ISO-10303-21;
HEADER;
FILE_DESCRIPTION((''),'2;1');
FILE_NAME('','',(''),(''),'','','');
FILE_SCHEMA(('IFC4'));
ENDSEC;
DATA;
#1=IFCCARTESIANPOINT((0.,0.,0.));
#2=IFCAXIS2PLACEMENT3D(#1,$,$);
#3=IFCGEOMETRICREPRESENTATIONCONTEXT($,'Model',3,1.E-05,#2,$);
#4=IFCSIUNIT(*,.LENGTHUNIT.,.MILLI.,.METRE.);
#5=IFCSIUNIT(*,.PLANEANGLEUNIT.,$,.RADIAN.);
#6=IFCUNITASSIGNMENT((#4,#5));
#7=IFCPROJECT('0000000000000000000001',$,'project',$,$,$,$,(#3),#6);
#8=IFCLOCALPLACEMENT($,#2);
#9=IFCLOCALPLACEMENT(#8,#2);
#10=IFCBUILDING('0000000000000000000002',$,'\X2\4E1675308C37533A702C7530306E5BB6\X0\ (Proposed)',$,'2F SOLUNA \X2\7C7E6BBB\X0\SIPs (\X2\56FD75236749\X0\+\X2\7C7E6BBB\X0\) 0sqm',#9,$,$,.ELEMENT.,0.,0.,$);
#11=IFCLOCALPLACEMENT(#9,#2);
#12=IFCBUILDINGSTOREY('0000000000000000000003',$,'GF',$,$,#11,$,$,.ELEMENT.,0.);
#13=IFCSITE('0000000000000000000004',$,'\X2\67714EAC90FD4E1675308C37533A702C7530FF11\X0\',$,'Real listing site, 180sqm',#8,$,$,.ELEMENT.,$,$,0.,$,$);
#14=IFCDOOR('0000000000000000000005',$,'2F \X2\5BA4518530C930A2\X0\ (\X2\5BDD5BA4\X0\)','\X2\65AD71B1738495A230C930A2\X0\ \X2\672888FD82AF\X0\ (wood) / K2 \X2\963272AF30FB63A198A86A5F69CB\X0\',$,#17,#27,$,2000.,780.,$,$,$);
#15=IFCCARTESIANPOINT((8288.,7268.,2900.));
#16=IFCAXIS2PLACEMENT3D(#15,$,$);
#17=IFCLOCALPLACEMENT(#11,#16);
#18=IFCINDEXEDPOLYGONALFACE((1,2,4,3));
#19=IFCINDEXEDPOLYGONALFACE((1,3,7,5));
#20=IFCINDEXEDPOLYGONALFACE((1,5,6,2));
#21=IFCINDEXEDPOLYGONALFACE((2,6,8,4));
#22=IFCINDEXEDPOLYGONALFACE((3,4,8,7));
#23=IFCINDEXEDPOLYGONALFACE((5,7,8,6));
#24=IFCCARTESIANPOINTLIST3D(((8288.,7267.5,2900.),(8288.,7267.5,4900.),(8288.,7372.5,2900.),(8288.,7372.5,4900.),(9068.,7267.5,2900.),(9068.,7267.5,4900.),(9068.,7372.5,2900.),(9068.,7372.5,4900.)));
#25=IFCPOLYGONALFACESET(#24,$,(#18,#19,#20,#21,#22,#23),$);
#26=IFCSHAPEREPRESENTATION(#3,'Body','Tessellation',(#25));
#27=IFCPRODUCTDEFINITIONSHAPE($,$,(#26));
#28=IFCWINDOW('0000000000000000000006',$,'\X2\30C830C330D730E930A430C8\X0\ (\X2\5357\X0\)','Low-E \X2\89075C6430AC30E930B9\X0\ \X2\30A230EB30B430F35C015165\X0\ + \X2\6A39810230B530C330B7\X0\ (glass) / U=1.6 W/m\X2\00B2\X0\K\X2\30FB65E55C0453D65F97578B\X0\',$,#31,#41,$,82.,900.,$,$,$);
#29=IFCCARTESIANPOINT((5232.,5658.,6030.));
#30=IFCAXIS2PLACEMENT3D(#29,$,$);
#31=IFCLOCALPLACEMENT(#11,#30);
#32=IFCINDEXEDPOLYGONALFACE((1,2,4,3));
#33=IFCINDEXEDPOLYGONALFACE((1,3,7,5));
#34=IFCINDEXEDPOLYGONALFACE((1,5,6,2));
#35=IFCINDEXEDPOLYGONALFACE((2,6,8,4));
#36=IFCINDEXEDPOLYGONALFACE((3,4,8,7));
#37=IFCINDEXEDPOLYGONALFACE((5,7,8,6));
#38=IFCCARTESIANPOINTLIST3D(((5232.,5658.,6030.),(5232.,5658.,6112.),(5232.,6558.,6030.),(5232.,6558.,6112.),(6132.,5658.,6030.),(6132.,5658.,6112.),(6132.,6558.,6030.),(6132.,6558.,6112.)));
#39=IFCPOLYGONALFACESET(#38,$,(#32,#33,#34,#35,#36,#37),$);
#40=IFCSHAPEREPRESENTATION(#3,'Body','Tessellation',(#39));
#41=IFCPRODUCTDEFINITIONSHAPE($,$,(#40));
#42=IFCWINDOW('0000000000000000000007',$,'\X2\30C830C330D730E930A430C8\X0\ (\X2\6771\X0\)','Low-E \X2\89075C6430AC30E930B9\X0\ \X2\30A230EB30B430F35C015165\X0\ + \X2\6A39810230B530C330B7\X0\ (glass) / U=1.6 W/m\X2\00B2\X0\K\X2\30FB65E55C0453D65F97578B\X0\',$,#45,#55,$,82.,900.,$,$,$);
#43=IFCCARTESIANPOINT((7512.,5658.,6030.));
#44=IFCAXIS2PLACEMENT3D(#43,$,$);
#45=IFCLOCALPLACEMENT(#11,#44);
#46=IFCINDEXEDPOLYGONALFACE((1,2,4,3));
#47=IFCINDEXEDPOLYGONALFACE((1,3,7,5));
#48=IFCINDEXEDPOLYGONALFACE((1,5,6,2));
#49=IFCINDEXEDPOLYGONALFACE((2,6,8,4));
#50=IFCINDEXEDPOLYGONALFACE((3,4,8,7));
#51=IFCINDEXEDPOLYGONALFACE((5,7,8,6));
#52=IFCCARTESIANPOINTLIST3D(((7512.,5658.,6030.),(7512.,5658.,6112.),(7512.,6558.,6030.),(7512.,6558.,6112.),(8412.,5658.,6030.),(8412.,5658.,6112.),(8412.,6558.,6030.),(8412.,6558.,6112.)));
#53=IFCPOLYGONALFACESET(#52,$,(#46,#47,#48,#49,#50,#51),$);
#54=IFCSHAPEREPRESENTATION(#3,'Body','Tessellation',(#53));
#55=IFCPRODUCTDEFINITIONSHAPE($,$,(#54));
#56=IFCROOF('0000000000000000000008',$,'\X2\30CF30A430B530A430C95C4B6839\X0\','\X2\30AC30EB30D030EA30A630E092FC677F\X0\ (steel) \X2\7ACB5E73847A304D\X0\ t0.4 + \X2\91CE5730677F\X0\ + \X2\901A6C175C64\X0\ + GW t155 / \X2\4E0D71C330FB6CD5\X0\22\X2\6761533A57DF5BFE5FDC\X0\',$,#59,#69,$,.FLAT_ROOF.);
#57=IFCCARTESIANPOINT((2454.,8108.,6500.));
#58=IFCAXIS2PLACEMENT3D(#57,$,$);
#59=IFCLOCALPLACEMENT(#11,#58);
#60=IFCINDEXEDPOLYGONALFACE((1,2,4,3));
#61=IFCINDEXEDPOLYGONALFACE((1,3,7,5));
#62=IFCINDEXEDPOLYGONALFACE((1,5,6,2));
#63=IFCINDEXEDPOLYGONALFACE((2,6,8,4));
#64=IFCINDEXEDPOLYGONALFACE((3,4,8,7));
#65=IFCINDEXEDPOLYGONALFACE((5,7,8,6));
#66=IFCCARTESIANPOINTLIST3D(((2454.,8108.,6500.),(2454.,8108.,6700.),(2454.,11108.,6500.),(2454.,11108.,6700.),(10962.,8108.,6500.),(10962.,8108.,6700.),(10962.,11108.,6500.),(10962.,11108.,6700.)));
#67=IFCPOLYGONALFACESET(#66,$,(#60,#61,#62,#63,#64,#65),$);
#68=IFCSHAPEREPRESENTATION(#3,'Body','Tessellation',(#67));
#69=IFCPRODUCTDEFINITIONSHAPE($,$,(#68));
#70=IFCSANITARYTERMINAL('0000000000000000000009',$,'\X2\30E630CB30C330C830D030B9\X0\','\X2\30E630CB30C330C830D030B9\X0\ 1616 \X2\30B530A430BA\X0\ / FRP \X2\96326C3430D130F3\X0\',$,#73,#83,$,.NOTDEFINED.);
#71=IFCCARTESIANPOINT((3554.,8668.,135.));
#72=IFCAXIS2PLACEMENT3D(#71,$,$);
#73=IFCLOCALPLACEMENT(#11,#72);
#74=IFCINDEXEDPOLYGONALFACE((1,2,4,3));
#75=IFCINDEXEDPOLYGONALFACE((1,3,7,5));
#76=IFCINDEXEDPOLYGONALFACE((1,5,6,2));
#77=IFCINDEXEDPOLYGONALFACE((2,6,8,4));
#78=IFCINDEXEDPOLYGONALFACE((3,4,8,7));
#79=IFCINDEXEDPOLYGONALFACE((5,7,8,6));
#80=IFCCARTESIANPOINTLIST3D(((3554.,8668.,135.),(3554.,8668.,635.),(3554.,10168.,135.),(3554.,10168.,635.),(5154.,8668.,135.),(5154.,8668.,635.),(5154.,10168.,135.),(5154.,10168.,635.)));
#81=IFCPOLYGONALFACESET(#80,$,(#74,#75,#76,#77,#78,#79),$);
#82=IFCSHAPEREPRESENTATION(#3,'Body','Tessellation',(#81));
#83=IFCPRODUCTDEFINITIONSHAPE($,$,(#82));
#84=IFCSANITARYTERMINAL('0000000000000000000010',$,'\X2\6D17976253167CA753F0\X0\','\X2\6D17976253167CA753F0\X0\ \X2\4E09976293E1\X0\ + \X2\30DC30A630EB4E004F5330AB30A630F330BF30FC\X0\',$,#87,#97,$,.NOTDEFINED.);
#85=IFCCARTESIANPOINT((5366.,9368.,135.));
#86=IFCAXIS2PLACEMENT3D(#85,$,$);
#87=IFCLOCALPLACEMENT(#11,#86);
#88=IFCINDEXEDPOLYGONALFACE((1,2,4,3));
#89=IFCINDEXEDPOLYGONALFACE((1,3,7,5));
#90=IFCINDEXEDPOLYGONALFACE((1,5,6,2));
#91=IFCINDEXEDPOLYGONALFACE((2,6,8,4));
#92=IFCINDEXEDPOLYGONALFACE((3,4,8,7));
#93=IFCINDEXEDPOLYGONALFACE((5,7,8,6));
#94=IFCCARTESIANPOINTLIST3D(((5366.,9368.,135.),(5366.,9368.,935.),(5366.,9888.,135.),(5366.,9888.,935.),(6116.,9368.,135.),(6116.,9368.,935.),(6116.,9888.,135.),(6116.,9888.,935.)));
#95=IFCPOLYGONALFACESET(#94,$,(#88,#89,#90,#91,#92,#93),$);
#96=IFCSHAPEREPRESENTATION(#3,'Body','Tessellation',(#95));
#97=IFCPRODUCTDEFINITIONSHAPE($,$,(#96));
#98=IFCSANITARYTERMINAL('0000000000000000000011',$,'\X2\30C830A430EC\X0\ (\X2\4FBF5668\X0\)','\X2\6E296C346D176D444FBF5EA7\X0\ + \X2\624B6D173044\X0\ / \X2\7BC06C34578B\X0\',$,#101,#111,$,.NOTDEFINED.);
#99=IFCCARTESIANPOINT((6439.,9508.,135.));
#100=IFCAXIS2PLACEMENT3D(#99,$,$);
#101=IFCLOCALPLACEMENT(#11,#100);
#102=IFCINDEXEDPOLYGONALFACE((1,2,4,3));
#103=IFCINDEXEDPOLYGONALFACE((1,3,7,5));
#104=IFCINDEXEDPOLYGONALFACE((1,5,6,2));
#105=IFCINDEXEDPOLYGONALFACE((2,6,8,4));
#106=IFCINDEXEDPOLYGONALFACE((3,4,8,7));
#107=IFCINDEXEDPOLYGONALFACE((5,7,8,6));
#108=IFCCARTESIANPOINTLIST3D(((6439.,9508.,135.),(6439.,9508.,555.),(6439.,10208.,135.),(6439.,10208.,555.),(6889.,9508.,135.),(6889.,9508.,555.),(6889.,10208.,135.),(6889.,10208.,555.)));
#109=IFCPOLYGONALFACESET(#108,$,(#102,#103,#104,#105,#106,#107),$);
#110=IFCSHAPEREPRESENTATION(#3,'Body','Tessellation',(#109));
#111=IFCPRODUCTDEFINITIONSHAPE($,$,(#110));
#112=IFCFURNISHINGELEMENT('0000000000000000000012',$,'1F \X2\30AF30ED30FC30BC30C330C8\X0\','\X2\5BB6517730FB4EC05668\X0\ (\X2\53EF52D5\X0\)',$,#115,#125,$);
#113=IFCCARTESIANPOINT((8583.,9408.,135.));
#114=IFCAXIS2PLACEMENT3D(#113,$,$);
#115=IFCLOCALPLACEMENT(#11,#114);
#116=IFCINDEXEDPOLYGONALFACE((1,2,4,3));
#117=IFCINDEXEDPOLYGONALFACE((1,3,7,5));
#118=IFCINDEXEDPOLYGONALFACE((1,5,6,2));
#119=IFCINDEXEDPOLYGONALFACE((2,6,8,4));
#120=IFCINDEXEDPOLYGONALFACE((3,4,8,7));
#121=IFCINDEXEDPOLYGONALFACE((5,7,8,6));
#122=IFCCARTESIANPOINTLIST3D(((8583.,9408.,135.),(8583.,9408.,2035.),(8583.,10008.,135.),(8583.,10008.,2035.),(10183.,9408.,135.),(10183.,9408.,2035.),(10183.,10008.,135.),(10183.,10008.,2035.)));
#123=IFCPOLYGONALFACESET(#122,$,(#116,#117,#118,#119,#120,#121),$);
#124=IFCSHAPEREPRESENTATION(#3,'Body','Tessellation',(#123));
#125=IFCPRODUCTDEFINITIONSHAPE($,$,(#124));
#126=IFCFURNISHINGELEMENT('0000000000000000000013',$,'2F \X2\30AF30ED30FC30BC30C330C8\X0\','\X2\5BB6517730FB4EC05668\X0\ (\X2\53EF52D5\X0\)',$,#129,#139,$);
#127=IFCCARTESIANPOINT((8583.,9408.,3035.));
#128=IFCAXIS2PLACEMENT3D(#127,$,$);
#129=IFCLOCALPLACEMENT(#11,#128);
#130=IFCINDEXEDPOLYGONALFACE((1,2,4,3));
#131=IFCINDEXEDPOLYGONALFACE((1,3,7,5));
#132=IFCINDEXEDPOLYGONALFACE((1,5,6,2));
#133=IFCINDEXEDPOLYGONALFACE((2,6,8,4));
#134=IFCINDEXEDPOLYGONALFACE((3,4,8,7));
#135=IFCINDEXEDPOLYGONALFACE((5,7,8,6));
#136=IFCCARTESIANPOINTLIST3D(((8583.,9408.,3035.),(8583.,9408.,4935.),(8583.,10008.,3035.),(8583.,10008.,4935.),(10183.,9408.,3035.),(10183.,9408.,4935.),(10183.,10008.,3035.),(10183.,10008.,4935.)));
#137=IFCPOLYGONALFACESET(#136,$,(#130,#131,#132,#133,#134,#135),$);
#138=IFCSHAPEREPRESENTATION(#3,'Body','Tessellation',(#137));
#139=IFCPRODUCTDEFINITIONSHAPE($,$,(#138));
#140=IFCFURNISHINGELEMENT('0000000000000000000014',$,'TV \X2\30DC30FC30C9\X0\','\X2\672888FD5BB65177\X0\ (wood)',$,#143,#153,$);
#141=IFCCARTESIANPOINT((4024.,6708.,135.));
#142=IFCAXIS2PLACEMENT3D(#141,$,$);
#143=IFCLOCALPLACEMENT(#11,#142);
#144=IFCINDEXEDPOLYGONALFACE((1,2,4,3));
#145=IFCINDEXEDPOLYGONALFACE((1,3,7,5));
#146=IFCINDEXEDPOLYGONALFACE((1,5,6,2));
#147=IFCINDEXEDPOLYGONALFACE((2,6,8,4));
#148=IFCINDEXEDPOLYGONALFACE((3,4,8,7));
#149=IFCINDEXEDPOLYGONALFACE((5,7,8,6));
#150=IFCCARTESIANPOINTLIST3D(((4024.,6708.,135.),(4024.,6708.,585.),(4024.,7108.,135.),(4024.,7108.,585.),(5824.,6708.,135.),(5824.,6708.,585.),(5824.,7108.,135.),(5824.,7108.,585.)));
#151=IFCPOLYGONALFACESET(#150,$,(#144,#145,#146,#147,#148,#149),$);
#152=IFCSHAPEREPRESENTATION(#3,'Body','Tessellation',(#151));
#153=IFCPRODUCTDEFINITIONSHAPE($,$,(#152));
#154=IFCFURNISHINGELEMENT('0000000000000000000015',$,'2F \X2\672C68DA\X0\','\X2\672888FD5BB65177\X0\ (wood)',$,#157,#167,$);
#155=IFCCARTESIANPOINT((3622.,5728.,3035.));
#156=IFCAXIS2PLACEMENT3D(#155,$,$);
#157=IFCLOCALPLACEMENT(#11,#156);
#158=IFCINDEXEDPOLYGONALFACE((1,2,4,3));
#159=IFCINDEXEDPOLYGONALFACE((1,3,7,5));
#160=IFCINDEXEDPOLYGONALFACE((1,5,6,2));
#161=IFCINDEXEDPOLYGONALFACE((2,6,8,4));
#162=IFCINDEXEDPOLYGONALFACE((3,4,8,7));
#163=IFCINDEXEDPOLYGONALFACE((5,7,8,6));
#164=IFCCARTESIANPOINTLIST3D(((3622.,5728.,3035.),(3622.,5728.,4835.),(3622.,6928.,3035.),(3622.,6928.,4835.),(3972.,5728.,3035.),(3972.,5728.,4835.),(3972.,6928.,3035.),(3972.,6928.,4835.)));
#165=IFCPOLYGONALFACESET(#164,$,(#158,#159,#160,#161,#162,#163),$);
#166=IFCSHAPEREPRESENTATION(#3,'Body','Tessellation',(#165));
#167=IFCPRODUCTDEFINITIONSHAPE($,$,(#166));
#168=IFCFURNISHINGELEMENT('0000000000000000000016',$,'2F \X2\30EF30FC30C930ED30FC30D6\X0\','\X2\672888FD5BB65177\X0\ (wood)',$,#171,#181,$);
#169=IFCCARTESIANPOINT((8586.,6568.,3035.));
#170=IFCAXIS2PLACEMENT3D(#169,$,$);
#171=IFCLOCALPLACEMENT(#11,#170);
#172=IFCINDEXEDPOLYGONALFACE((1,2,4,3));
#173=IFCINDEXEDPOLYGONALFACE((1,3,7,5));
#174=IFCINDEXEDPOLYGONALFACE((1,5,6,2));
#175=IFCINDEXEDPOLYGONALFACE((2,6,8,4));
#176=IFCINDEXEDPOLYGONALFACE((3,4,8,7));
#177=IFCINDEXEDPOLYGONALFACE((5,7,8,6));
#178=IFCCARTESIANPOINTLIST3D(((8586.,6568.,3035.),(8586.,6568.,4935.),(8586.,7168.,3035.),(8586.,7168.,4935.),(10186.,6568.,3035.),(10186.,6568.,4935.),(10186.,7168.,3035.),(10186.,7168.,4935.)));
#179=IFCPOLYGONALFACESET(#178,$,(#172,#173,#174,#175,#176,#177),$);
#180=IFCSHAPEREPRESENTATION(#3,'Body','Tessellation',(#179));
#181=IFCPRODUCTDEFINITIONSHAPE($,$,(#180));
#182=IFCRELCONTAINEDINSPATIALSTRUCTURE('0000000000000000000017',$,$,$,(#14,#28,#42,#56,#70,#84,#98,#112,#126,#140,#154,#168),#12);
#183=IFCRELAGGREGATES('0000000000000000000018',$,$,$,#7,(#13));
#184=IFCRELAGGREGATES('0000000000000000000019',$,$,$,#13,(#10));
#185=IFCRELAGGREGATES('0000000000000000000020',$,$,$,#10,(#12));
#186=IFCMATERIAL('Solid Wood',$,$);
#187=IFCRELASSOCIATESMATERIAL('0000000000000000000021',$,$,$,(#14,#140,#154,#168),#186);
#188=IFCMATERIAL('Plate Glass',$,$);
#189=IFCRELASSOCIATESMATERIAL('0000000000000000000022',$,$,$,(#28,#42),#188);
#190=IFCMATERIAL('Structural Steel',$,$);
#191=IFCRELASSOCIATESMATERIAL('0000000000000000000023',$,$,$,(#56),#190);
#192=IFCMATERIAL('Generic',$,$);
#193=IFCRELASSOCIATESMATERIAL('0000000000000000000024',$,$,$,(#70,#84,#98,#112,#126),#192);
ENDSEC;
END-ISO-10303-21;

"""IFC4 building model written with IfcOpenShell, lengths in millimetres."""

from ifc_helpers import new_model, si_unit, frame, frame_2d, origin, place, context, project, spatial, rectangle, extrude, material, element, save


model = new_model("IFC4")

# Units and contexts
model_context = context("Model", 3, precision=1e-05, world=origin())
ifc_project = project(units=[si_unit("LENGTHUNIT", "METRE", prefix="MILLI"), si_unit("PLANEANGLEUNIT", "RADIAN")], contexts=[model_context])

# Site, building, storey
site_placement = place(None, origin())
site = spatial("IfcSite", under=ifc_project, at=site_placement, Name="東京都世田谷区瀬田１", ObjectType="Real listing site, 180sqm", CompositionType="ELEMENT", RefElevation=0.0)
building_placement = place(site_placement, origin())
building = spatial("IfcBuilding", under=site, at=building_placement, Name="世田谷区瀬田の家 (Proposed)", ObjectType="2F SOLUNA 籾殻SIPs (国産杉+籾殻) 0sqm", CompositionType="ELEMENT", ElevationOfRefHeight=0.0, ElevationOfTerrain=0.0)
storey_placement = place(building_placement, origin())
storey = spatial("IfcBuildingStorey", under=building, at=storey_placement, Name="GF", CompositionType="ELEMENT", Elevation=0.0)

# Shared definitions
ifc_material_1 = material(Name="Solid Wood")
ifc_material_2 = material(Name="Plate Glass")

# Door
door_1_placement = place(storey_placement, frame((8288.0, 7268.0, 2900.0)))
element("IfcDoor", 1, at=door_1_placement, inside=storey, material=ifc_material_1, Name="2F 室内ドア (寝室)", Description="断熱玄関ドア 木製芯 (wood) / K2 防犯・採風機構", OverallHeight=2000.0, OverallWidth=780.0, context=model_context, shape_type="SweptSolid", body=[
    extrude(rectangle(XDim=780.0, YDim=105.0, at=frame_2d((390.0, 52.0))), frame((8288.0, 7268.0, 2900.0)), (0.0, 0.0, 1.0), 2000.0),
])

# Windows
window_1_placement = place(storey_placement, frame((5232.0, 5658.0, 6030.0)))
element("IfcWindow", 2, at=window_1_placement, inside=storey, material=ifc_material_2, Name="トップライト (南)", Description="Low-E 複層ガラス アルゴン封入 + 樹脂サッシ (glass) / U=1.6 W/m²K・日射取得型", OverallHeight=82.0, OverallWidth=900.0, context=model_context, shape_type="SweptSolid", body=[
    extrude(rectangle(XDim=900.0, YDim=900.0, at=frame_2d((450.0, 450.0))), frame((5232.0, 5658.0, 6030.0)), (0.0, 0.0, 1.0), 82.0),
])
window_2_placement = place(storey_placement, frame((7512.0, 5658.0, 6030.0)))
element("IfcWindow", 3, at=window_2_placement, inside=storey, material=ifc_material_2, Name="トップライト (東)", Description="Low-E 複層ガラス アルゴン封入 + 樹脂サッシ (glass) / U=1.6 W/m²K・日射取得型", OverallHeight=82.0, OverallWidth=900.0, context=model_context, shape_type="SweptSolid", body=[
    extrude(rectangle(XDim=900.0, YDim=900.0, at=frame_2d((450.0, 450.0))), frame((7512.0, 5658.0, 6030.0)), (0.0, 0.0, 1.0), 82.0),
])

# Roof
ifc_material_3 = material(Name="Structural Steel")
roof_placement = place(storey_placement, frame((2454.0, 8108.0, 6500.0)))
element("IfcRoof", 4, at=roof_placement, inside=storey, material=ifc_material_3, Name="ハイサイド屋根", Description="ガルバリウム鋼板 (steel) 立平葺き t0.4 + 野地板 + 通気層 + GW t155 / 不燃・法22条区域対応", PredefinedType="FLAT_ROOF", context=model_context, shape_type="SweptSolid", body=[
    extrude(rectangle(XDim=8508.0, YDim=3000.0, at=frame_2d((4254.0, 1500.0))), frame((2454.0, 8108.0, 6500.0)), (0.0, 0.0, 1.0), 200.0),
])

# Sanitary terminals
ifc_material_4 = material(Name="Generic")
sanitary_terminal_1_placement = place(storey_placement, frame((3554.0, 8668.0, 135.0)))
element("IfcSanitaryTerminal", 5, at=sanitary_terminal_1_placement, inside=storey, material=ifc_material_4, Name="ユニットバス", Description="ユニットバス 1616 サイズ / FRP 防水パン", PredefinedType="NOTDEFINED", context=model_context, shape_type="SweptSolid", body=[
    extrude(rectangle(XDim=1600.0, YDim=1500.0, at=frame_2d((800.0, 750.0))), frame((3554.0, 8668.0, 135.0)), (0.0, 0.0, 1.0), 500.0),
])
sanitary_terminal_2_placement = place(storey_placement, frame((5366.0, 9368.0, 135.0)))
element("IfcSanitaryTerminal", 6, at=sanitary_terminal_2_placement, inside=storey, material=ifc_material_4, Name="洗面化粧台", Description="洗面化粧台 三面鏡 + ボウル一体カウンター", PredefinedType="NOTDEFINED", context=model_context, shape_type="SweptSolid", body=[
    extrude(rectangle(XDim=750.0, YDim=520.0, at=frame_2d((375.0, 260.0))), frame((5366.0, 9368.0, 135.0)), (0.0, 0.0, 1.0), 800.0),
])
sanitary_terminal_3_placement = place(storey_placement, frame((6439.0, 9508.0, 135.0)))
element("IfcSanitaryTerminal", 7, at=sanitary_terminal_3_placement, inside=storey, material=ifc_material_4, Name="トイレ (便器)", Description="温水洗浄便座 + 手洗い / 節水型", PredefinedType="NOTDEFINED", context=model_context, shape_type="SweptSolid", body=[
    extrude(rectangle(XDim=450.0, YDim=700.0, at=frame_2d((225.0, 350.0))), frame((6439.0, 9508.0, 135.0)), (0.0, 0.0, 1.0), 420.0),
])

# Furnishing elements
furnishing_1_placement = place(storey_placement, frame((8583.0, 9408.0, 135.0)))
element("IfcFurnishingElement", 8, at=furnishing_1_placement, inside=storey, material=ifc_material_4, Name="1F クローゼット", Description="家具・什器 (可動)", context=model_context, shape_type="SweptSolid", body=[
    extrude(rectangle(XDim=1600.0, YDim=600.0, at=frame_2d((800.0, 300.0))), frame((8583.0, 9408.0, 135.0)), (0.0, 0.0, 1.0), 1900.0),
])
furnishing_2_placement = place(storey_placement, frame((8583.0, 9408.0, 3035.0)))
element("IfcFurnishingElement", 9, at=furnishing_2_placement, inside=storey, material=ifc_material_4, Name="2F クローゼット", Description="家具・什器 (可動)", context=model_context, shape_type="SweptSolid", body=[
    extrude(rectangle(XDim=1600.0, YDim=600.0, at=frame_2d((800.0, 300.0))), frame((8583.0, 9408.0, 3035.0)), (0.0, 0.0, 1.0), 1900.0),
])
furnishing_3_placement = place(storey_placement, frame((4024.0, 6708.0, 135.0)))
element("IfcFurnishingElement", 10, at=furnishing_3_placement, inside=storey, material=ifc_material_1, Name="TV ボード", Description="木製家具 (wood)", context=model_context, shape_type="SweptSolid", body=[
    extrude(rectangle(XDim=1800.0, YDim=400.0, at=frame_2d((900.0, 200.0))), frame((4024.0, 6708.0, 135.0)), (0.0, 0.0, 1.0), 450.0),
])
furnishing_4_placement = place(storey_placement, frame((3622.0, 5728.0, 3035.0)))
element("IfcFurnishingElement", 11, at=furnishing_4_placement, inside=storey, material=ifc_material_1, Name="2F 本棚", Description="木製家具 (wood)", context=model_context, shape_type="SweptSolid", body=[
    extrude(rectangle(XDim=350.0, YDim=1200.0, at=frame_2d((175.0, 600.0))), frame((3622.0, 5728.0, 3035.0)), (0.0, 0.0, 1.0), 1800.0),
])
furnishing_5_placement = place(storey_placement, frame((8586.0, 6568.0, 3035.0)))
element("IfcFurnishingElement", 12, at=furnishing_5_placement, inside=storey, material=ifc_material_1, Name="2F ワードローブ", Description="木製家具 (wood)", context=model_context, shape_type="SweptSolid", body=[
    extrude(rectangle(XDim=1600.0, YDim=600.0, at=frame_2d((800.0, 300.0))), frame((8586.0, 6568.0, 3035.0)), (0.0, 0.0, 1.0), 1900.0),
])

save(model, "model.ifc")
